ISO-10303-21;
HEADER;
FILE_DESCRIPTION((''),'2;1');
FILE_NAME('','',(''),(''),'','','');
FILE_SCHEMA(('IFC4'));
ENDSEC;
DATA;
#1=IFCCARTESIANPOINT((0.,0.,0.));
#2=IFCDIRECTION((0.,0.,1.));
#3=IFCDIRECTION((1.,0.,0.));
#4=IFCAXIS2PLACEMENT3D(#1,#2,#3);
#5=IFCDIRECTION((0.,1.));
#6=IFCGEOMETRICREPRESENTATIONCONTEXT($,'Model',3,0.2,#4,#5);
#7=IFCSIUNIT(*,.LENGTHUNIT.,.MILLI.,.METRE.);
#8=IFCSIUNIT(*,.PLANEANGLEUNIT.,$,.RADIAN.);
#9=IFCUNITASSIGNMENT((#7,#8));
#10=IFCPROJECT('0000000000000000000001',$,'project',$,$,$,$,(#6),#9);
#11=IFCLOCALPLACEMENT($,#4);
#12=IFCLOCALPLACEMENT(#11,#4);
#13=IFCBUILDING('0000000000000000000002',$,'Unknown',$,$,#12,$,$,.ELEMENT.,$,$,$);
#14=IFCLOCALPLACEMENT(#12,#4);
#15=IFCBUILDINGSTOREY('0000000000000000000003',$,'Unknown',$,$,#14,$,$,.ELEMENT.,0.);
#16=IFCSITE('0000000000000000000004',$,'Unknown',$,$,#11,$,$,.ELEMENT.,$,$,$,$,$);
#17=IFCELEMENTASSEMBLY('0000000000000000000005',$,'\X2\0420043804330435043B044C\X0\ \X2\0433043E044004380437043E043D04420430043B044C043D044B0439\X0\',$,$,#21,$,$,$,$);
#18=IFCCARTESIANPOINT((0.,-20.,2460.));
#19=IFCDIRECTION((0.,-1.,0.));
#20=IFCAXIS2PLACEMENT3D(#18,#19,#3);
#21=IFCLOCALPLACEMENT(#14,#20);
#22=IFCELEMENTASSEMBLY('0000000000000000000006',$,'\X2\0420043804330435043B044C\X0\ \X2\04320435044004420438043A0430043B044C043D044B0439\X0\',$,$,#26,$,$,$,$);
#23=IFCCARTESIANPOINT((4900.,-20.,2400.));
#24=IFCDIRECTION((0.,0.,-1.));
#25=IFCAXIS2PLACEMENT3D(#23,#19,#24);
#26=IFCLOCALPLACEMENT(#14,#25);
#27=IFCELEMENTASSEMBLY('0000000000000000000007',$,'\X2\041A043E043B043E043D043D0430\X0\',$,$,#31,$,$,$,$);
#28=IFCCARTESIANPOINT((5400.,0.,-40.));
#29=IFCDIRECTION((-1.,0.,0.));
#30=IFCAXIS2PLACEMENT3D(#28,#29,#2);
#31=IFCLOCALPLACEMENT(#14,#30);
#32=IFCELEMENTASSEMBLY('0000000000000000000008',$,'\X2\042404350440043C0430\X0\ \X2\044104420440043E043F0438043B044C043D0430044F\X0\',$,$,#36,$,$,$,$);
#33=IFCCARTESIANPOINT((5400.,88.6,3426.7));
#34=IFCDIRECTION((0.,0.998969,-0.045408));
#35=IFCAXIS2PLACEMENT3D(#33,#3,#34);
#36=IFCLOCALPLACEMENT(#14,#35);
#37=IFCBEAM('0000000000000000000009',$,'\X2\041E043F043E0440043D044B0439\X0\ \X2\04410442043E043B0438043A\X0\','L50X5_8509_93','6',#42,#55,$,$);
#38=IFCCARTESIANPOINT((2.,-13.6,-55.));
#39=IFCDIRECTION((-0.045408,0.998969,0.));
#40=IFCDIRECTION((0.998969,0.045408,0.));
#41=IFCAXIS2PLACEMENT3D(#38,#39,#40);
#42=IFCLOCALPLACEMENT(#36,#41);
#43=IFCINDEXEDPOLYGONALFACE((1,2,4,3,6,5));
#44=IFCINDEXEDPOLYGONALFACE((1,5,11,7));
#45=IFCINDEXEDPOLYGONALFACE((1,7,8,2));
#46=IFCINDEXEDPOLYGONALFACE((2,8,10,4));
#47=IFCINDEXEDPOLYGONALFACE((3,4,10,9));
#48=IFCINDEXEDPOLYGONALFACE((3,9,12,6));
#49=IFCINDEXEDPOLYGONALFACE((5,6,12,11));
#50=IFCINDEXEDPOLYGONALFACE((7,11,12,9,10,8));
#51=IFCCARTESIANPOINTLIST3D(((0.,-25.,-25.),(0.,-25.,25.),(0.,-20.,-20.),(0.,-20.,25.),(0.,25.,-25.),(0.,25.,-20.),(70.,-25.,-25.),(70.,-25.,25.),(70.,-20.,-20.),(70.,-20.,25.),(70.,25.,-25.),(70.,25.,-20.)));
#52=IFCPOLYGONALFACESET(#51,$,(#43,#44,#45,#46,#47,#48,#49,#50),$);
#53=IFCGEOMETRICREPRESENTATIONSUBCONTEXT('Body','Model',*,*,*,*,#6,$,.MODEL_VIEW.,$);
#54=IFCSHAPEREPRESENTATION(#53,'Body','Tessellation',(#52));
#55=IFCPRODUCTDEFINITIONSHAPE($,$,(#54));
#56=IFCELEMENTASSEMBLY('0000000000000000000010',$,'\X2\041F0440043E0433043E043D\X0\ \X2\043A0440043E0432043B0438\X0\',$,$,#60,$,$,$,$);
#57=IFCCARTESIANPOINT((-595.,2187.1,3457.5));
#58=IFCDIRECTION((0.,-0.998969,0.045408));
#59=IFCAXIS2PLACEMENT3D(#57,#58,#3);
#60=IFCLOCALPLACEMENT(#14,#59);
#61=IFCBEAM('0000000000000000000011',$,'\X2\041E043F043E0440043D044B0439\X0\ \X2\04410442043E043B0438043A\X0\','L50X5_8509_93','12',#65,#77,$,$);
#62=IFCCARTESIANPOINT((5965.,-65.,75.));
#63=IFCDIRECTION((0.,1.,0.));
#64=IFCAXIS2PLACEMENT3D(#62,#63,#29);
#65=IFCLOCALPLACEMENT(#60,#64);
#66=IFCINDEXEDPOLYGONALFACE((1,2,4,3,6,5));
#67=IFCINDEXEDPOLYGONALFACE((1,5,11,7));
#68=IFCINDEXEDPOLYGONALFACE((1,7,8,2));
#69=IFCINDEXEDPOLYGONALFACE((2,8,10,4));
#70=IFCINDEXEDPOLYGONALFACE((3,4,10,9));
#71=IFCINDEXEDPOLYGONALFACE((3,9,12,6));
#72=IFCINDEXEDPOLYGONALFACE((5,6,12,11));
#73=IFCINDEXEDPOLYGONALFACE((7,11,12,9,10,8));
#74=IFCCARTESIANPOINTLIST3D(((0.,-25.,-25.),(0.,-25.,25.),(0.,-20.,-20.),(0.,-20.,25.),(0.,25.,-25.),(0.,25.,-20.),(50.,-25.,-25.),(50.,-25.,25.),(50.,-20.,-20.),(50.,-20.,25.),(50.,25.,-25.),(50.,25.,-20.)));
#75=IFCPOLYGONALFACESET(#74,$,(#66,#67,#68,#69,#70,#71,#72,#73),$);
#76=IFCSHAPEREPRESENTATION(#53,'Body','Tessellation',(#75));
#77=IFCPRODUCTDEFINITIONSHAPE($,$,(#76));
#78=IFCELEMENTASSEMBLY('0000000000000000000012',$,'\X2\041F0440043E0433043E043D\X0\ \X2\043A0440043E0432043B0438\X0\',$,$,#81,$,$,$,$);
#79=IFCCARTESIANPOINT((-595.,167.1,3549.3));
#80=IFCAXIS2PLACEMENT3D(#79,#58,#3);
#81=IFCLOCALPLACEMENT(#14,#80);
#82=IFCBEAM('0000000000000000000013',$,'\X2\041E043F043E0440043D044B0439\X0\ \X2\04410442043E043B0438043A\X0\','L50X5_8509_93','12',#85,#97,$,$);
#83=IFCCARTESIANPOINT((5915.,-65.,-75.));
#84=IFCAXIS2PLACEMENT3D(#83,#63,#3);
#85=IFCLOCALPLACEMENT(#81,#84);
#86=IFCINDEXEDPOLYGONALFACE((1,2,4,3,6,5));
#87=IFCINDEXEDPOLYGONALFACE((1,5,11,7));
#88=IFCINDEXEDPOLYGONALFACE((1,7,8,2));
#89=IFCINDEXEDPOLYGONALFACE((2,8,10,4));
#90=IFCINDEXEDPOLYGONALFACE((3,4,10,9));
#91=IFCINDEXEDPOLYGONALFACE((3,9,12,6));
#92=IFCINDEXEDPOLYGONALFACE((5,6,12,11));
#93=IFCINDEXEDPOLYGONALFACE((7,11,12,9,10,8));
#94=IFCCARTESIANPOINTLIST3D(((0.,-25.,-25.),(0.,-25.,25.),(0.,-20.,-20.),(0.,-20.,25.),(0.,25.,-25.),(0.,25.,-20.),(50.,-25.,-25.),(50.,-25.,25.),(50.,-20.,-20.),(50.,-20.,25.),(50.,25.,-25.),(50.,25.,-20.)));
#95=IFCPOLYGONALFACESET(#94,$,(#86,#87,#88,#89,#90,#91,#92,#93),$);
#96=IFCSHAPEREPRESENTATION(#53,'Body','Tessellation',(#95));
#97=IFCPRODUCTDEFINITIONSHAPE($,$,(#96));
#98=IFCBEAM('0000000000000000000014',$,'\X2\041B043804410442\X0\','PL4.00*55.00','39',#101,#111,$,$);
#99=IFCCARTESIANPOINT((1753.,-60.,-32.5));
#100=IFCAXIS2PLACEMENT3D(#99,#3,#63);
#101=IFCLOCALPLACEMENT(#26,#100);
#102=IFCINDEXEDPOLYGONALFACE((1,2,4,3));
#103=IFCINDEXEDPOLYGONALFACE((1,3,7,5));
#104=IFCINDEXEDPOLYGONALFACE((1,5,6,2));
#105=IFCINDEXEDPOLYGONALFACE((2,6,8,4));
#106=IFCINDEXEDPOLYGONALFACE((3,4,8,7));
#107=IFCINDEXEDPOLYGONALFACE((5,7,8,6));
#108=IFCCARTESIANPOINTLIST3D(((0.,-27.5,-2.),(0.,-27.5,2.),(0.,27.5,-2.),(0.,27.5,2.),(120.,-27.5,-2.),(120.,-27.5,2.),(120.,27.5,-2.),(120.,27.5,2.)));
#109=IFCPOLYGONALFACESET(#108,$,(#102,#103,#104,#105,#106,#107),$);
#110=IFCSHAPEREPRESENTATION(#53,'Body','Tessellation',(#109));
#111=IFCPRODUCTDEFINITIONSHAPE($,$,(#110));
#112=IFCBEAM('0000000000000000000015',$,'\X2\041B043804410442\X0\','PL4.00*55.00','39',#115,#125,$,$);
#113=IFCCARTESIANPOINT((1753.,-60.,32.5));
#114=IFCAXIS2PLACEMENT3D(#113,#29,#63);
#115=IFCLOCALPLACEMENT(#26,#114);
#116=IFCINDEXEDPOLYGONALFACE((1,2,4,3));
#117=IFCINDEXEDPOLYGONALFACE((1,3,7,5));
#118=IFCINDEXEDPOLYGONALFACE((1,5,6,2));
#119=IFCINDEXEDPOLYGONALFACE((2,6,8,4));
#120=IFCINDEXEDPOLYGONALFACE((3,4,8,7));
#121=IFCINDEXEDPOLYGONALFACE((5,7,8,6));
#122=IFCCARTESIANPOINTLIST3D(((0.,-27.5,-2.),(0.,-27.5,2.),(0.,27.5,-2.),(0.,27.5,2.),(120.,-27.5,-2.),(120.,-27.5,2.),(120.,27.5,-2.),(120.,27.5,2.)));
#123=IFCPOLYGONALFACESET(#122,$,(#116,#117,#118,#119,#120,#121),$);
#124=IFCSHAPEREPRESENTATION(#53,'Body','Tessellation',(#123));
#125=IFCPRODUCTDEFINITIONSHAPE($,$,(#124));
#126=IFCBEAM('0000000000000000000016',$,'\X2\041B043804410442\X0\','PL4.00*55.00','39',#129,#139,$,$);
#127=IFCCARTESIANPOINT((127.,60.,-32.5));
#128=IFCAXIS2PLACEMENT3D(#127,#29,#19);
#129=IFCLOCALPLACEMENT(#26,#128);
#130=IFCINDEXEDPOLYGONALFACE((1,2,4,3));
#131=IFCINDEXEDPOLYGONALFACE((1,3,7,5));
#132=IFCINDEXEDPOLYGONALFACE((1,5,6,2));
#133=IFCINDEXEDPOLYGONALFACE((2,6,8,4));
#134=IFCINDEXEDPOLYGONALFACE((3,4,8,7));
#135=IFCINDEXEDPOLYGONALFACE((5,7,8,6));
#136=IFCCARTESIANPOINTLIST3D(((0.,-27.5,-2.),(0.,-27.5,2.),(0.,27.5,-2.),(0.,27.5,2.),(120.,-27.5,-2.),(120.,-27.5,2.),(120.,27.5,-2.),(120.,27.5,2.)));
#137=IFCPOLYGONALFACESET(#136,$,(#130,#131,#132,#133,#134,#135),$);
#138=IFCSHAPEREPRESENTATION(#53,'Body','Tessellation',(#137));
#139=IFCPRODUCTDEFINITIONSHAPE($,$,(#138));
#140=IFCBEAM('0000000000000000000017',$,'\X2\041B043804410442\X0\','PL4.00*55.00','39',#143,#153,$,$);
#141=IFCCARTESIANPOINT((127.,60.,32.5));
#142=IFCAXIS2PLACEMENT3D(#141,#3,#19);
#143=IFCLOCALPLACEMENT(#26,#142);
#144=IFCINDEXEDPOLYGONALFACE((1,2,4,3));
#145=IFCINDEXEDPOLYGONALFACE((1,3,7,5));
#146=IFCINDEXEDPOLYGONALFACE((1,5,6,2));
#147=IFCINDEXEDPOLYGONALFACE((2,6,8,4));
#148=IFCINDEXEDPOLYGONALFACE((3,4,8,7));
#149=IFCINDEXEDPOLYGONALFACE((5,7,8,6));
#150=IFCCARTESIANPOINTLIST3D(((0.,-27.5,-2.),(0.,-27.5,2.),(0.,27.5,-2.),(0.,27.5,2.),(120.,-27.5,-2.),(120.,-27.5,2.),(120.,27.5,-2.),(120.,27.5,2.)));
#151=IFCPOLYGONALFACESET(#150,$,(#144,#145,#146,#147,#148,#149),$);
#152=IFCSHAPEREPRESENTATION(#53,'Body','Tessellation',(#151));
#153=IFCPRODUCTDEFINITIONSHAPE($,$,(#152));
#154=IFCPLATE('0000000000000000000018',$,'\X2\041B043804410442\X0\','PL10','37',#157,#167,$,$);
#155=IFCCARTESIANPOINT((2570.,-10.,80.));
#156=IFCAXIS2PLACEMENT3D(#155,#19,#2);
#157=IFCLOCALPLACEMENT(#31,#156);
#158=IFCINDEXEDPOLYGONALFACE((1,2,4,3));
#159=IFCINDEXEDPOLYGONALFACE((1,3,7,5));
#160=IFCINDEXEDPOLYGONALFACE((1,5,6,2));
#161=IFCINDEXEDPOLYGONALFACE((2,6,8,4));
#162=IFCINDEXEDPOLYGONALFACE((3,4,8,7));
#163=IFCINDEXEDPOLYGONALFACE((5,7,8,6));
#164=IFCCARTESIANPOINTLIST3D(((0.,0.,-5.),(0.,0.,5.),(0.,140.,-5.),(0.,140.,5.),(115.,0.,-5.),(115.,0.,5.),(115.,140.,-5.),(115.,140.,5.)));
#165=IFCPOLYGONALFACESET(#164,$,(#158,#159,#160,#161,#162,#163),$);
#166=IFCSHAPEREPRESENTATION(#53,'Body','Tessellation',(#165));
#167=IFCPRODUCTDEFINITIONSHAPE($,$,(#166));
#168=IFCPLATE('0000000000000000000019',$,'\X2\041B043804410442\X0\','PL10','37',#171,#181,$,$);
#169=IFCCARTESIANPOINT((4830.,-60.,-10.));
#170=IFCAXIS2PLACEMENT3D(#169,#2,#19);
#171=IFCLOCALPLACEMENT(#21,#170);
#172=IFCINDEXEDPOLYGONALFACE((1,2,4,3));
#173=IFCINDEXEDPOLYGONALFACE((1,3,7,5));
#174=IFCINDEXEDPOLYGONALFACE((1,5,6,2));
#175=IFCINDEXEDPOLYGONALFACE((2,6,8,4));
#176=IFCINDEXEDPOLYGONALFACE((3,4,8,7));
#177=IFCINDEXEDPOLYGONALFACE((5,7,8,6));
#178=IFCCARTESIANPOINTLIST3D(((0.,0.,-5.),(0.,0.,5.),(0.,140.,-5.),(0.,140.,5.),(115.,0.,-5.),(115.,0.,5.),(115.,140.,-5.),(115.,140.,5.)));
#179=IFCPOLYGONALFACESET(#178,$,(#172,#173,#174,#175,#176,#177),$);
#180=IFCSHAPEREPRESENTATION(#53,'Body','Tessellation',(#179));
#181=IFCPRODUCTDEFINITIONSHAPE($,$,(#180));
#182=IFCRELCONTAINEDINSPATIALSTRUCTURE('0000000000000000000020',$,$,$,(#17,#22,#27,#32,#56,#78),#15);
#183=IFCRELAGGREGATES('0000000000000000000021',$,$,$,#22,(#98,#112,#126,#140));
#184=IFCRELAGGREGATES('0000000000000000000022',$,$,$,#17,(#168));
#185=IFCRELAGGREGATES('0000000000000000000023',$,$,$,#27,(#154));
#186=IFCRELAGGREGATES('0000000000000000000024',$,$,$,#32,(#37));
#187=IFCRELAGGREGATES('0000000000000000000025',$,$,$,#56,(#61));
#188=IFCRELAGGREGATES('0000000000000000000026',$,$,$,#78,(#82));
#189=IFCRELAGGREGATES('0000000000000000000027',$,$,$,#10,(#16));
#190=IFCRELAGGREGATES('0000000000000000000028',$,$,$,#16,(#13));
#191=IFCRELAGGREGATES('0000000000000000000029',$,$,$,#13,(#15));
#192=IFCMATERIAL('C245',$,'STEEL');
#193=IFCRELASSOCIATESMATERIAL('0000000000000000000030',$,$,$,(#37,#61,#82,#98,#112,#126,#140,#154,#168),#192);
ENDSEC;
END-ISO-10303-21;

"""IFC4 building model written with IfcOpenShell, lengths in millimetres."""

from ifc_helpers import new_model, si_unit, direction, frame, origin_with_axes, place, context, subcontext, project, spatial, line, indexed_curve, outline, extrude, material, element, aggregate, save


model = new_model("IFC4")

# Units and contexts
model_context = context("Model", 3, precision=0.2, world=origin_with_axes(), true_north=direction((0.0, 1.0)))
body_context = subcontext(model_context, "Body", "Model", "MODEL_VIEW")
ifc_project = project(units=[si_unit("LENGTHUNIT", "METRE", prefix="MILLI"), si_unit("PLANEANGLEUNIT", "RADIAN")], contexts=[model_context])

# Site, building, storey
site_placement = place(None, origin_with_axes())
site = spatial("IfcSite", under=ifc_project, at=site_placement, Name="Unknown", CompositionType="ELEMENT")
building_placement = place(site_placement, origin_with_axes())
building = spatial("IfcBuilding", under=site, at=building_placement, Name="Unknown", CompositionType="ELEMENT")
storey_placement = place(building_placement, origin_with_axes())
storey = spatial("IfcBuildingStorey", under=building, at=storey_placement, Name="Unknown", CompositionType="ELEMENT", Elevation=0.0)

# Element assembly
assembly_1_placement = place(storey_placement, frame((0.0, -20.0, 2460.0), z_axis=(0.0, -1.0, 0.0), x_axis=(1.0, 0.0, 0.0)))
assembly_1 = element("IfcElementAssembly", 1, at=assembly_1_placement, inside=storey, Name="Ригель горизонтальный")
ifc_material_1 = material(Name="C245", Category="STEEL")

# Element assembly
assembly_2_placement = place(storey_placement, frame((4900.0, -20.0, 2400.0), z_axis=(0.0, -1.0, 0.0), x_axis=(0.0, 0.0, -1.0)))
assembly_2 = element("IfcElementAssembly", 2, at=assembly_2_placement, inside=storey, Name="Ригель вертикальный")

# Element assembly
assembly_3_placement = place(storey_placement, frame((5400.0, 0.0, -40.0), z_axis=(-1.0, 0.0, 0.0), x_axis=(0.0, 0.0, 1.0)))
assembly_3 = element("IfcElementAssembly", 3, at=assembly_3_placement, inside=storey, Name="Колонна")

# Element assembly, beam
assembly_4_placement = place(storey_placement, frame((5400.0, 88.6, 3426.7), z_axis=(1.0, 0.0, 0.0), x_axis=(0.0, 0.998969, -0.045408)))
assembly_4 = element("IfcElementAssembly", 4, at=assembly_4_placement, inside=storey, Name="Ферма стропильная")
beam_1_placement = place(assembly_4_placement, frame((2.0, -13.6, -55.0), z_axis=(-0.045408, 0.998969, 0.0), x_axis=(0.998969, 0.045408, 0.0)))
beam_1 = element("IfcBeam", 5, at=beam_1_placement, material=ifc_material_1, Name="Опорный столик", Description="L50X5_8509_93", ObjectType="6", context=body_context, shape_type="SolidModel", body=[
    extrude(outline(indexed_curve([(-25.0, -25.0), (25.0, -25.0), (25.0, -20.0), (-20.0, -20.0), (-20.0, 25.0), (-25.0, 25.0)], segments=[line(1, 2, 3, 4, 5, 6, 1)])), frame((0.0, 0.0, 0.0), z_axis=(-1.0, 0.0, 0.0), x_axis=(0.0, 0.0, 1.0)), (0.0, 0.0, -1.0), 70.0),
])

# Element assembly, beam
assembly_5_placement = place(storey_placement, frame((-595.0, 2187.1, 3457.5), z_axis=(0.0, -0.998969, 0.045408), x_axis=(1.0, 0.0, 0.0)))
assembly_5 = element("IfcElementAssembly", 6, at=assembly_5_placement, inside=storey, Name="Прогон кровли")
beam_2_placement = place(assembly_5_placement, frame((5965.0, -65.0, 75.0), z_axis=(0.0, 1.0, 0.0), x_axis=(-1.0, 0.0, 0.0)))
beam_2 = element("IfcBeam", 7, at=beam_2_placement, material=ifc_material_1, Name="Опорный столик", Description="L50X5_8509_93", ObjectType="12", context=body_context, shape_type="SolidModel", body=[
    extrude(outline(indexed_curve([(-25.0, -25.0), (25.0, -25.0), (25.0, -20.0), (-20.0, -20.0), (-20.0, 25.0), (-25.0, 25.0)], segments=[line(1, 2, 3, 4, 5, 6, 1)])), frame((0.0, 0.0, 0.0), z_axis=(-1.0, 0.0, 0.0), x_axis=(0.0, 0.0, 1.0)), (0.0, 0.0, -1.0), 50.0),
])

# Element assembly, beam
assembly_6_placement = place(storey_placement, frame((-595.0, 167.1, 3549.3), z_axis=(0.0, -0.998969, 0.045408), x_axis=(1.0, 0.0, 0.0)))
assembly_6 = element("IfcElementAssembly", 8, at=assembly_6_placement, inside=storey, Name="Прогон кровли")
beam_3_placement = place(assembly_6_placement, frame((5915.0, -65.0, -75.0), z_axis=(0.0, 1.0, 0.0), x_axis=(1.0, 0.0, 0.0)))
beam_3 = element("IfcBeam", 9, at=beam_3_placement, material=ifc_material_1, Name="Опорный столик", Description="L50X5_8509_93", ObjectType="12", context=body_context, shape_type="SolidModel", body=[
    extrude(outline(indexed_curve([(-25.0, -25.0), (25.0, -25.0), (25.0, -20.0), (-20.0, -20.0), (-20.0, 25.0), (-25.0, 25.0)], segments=[line(1, 2, 3, 4, 5, 6, 1)])), frame((0.0, 0.0, 0.0), z_axis=(-1.0, 0.0, 0.0), x_axis=(0.0, 0.0, 1.0)), (0.0, 0.0, -1.0), 50.0),
])

# Beams
beam_4_placement = place(assembly_2_placement, frame((1753.0, -60.0, -32.5), z_axis=(1.0, 0.0, 0.0), x_axis=(0.0, 1.0, 0.0)))
beam_4 = element("IfcBeam", 10, at=beam_4_placement, material=ifc_material_1, Name="Лист", Description="PL4.00*55.00", ObjectType="39", context=body_context, shape_type="SolidModel", body=[
    extrude(outline(indexed_curve([(-2.0, -27.5), (2.0, -27.5), (2.0, 27.5), (-2.0, 27.5)], segments=[line(1, 2, 3, 4, 1)])), frame((0.0, 0.0, 0.0), z_axis=(-1.0, 0.0, 0.0), x_axis=(0.0, 0.0, 1.0)), (0.0, 0.0, -1.0), 120.0),
])
beam_5_placement = place(assembly_2_placement, frame((1753.0, -60.0, 32.5), z_axis=(-1.0, 0.0, 0.0), x_axis=(0.0, 1.0, 0.0)))
beam_5 = element("IfcBeam", 11, at=beam_5_placement, material=ifc_material_1, Name="Лист", Description="PL4.00*55.00", ObjectType="39", context=body_context, shape_type="SolidModel", body=[
    extrude(outline(indexed_curve([(-2.0, -27.5), (2.0, -27.5), (2.0, 27.5), (-2.0, 27.5)], segments=[line(1, 2, 3, 4, 1)])), frame((0.0, 0.0, 0.0), z_axis=(-1.0, 0.0, 0.0), x_axis=(0.0, 0.0, 1.0)), (0.0, 0.0, -1.0), 120.0),
])
beam_6_placement = place(assembly_2_placement, frame((127.0, 60.0, -32.5), z_axis=(-1.0, 0.0, 0.0), x_axis=(0.0, -1.0, 0.0)))
beam_6 = element("IfcBeam", 12, at=beam_6_placement, material=ifc_material_1, Name="Лист", Description="PL4.00*55.00", ObjectType="39", context=body_context, shape_type="SolidModel", body=[
    extrude(outline(indexed_curve([(-2.0, -27.5), (2.0, -27.5), (2.0, 27.5), (-2.0, 27.5)], segments=[line(1, 2, 3, 4, 1)])), frame((0.0, 0.0, 0.0), z_axis=(-1.0, 0.0, 0.0), x_axis=(0.0, 0.0, 1.0)), (0.0, 0.0, -1.0), 120.0),
])
beam_7_placement = place(assembly_2_placement, frame((127.0, 60.0, 32.5), z_axis=(1.0, 0.0, 0.0), x_axis=(0.0, -1.0, 0.0)))
beam_7 = element("IfcBeam", 13, at=beam_7_placement, material=ifc_material_1, Name="Лист", Description="PL4.00*55.00", ObjectType="39", context=body_context, shape_type="SolidModel", body=[
    extrude(outline(indexed_curve([(-2.0, -27.5), (2.0, -27.5), (2.0, 27.5), (-2.0, 27.5)], segments=[line(1, 2, 3, 4, 1)])), frame((0.0, 0.0, 0.0), z_axis=(-1.0, 0.0, 0.0), x_axis=(0.0, 0.0, 1.0)), (0.0, 0.0, -1.0), 120.0),
])
aggregate(assembly_2, [beam_4, beam_5, beam_6, beam_7])

# Plates
plate_1_placement = place(assembly_3_placement, frame((2570.0, -10.0, 80.0), z_axis=(0.0, -1.0, 0.0), x_axis=(0.0, 0.0, 1.0)))
plate_1 = element("IfcPlate", 14, at=plate_1_placement, material=ifc_material_1, Name="Лист", Description="PL10", ObjectType="37", context=body_context, shape_type="SolidModel", body=[
    extrude(outline(indexed_curve([(0.0, 0.0), (115.0, 0.0), (115.0, 140.0), (0.0, 140.0)], segments=[line(1, 2, 3, 4, 1)])), frame((0.0, 0.0, 5.0), z_axis=(0.0, 0.0, 1.0), x_axis=(1.0, 0.0, 0.0)), (0.0, 0.0, -1.0), 10.0),
])
plate_2_placement = place(assembly_1_placement, frame((4830.0, -60.0, -10.0), z_axis=(0.0, 0.0, 1.0), x_axis=(0.0, -1.0, 0.0)))
plate_2 = element("IfcPlate", 15, at=plate_2_placement, material=ifc_material_1, Name="Лист", Description="PL10", ObjectType="37", context=body_context, shape_type="SolidModel", body=[
    extrude(outline(indexed_curve([(0.0, 0.0), (115.0, 0.0), (115.0, 140.0), (0.0, 140.0)], segments=[line(1, 2, 3, 4, 1)])), frame((0.0, 0.0, 5.0), z_axis=(0.0, 0.0, 1.0), x_axis=(1.0, 0.0, 0.0)), (0.0, 0.0, -1.0), 10.0),
])

aggregate(assembly_1, [plate_2])
aggregate(assembly_3, [plate_1])
aggregate(assembly_4, [beam_1])
aggregate(assembly_5, [beam_2])
aggregate(assembly_6, [beam_3])

save(model, "model.ifc")
